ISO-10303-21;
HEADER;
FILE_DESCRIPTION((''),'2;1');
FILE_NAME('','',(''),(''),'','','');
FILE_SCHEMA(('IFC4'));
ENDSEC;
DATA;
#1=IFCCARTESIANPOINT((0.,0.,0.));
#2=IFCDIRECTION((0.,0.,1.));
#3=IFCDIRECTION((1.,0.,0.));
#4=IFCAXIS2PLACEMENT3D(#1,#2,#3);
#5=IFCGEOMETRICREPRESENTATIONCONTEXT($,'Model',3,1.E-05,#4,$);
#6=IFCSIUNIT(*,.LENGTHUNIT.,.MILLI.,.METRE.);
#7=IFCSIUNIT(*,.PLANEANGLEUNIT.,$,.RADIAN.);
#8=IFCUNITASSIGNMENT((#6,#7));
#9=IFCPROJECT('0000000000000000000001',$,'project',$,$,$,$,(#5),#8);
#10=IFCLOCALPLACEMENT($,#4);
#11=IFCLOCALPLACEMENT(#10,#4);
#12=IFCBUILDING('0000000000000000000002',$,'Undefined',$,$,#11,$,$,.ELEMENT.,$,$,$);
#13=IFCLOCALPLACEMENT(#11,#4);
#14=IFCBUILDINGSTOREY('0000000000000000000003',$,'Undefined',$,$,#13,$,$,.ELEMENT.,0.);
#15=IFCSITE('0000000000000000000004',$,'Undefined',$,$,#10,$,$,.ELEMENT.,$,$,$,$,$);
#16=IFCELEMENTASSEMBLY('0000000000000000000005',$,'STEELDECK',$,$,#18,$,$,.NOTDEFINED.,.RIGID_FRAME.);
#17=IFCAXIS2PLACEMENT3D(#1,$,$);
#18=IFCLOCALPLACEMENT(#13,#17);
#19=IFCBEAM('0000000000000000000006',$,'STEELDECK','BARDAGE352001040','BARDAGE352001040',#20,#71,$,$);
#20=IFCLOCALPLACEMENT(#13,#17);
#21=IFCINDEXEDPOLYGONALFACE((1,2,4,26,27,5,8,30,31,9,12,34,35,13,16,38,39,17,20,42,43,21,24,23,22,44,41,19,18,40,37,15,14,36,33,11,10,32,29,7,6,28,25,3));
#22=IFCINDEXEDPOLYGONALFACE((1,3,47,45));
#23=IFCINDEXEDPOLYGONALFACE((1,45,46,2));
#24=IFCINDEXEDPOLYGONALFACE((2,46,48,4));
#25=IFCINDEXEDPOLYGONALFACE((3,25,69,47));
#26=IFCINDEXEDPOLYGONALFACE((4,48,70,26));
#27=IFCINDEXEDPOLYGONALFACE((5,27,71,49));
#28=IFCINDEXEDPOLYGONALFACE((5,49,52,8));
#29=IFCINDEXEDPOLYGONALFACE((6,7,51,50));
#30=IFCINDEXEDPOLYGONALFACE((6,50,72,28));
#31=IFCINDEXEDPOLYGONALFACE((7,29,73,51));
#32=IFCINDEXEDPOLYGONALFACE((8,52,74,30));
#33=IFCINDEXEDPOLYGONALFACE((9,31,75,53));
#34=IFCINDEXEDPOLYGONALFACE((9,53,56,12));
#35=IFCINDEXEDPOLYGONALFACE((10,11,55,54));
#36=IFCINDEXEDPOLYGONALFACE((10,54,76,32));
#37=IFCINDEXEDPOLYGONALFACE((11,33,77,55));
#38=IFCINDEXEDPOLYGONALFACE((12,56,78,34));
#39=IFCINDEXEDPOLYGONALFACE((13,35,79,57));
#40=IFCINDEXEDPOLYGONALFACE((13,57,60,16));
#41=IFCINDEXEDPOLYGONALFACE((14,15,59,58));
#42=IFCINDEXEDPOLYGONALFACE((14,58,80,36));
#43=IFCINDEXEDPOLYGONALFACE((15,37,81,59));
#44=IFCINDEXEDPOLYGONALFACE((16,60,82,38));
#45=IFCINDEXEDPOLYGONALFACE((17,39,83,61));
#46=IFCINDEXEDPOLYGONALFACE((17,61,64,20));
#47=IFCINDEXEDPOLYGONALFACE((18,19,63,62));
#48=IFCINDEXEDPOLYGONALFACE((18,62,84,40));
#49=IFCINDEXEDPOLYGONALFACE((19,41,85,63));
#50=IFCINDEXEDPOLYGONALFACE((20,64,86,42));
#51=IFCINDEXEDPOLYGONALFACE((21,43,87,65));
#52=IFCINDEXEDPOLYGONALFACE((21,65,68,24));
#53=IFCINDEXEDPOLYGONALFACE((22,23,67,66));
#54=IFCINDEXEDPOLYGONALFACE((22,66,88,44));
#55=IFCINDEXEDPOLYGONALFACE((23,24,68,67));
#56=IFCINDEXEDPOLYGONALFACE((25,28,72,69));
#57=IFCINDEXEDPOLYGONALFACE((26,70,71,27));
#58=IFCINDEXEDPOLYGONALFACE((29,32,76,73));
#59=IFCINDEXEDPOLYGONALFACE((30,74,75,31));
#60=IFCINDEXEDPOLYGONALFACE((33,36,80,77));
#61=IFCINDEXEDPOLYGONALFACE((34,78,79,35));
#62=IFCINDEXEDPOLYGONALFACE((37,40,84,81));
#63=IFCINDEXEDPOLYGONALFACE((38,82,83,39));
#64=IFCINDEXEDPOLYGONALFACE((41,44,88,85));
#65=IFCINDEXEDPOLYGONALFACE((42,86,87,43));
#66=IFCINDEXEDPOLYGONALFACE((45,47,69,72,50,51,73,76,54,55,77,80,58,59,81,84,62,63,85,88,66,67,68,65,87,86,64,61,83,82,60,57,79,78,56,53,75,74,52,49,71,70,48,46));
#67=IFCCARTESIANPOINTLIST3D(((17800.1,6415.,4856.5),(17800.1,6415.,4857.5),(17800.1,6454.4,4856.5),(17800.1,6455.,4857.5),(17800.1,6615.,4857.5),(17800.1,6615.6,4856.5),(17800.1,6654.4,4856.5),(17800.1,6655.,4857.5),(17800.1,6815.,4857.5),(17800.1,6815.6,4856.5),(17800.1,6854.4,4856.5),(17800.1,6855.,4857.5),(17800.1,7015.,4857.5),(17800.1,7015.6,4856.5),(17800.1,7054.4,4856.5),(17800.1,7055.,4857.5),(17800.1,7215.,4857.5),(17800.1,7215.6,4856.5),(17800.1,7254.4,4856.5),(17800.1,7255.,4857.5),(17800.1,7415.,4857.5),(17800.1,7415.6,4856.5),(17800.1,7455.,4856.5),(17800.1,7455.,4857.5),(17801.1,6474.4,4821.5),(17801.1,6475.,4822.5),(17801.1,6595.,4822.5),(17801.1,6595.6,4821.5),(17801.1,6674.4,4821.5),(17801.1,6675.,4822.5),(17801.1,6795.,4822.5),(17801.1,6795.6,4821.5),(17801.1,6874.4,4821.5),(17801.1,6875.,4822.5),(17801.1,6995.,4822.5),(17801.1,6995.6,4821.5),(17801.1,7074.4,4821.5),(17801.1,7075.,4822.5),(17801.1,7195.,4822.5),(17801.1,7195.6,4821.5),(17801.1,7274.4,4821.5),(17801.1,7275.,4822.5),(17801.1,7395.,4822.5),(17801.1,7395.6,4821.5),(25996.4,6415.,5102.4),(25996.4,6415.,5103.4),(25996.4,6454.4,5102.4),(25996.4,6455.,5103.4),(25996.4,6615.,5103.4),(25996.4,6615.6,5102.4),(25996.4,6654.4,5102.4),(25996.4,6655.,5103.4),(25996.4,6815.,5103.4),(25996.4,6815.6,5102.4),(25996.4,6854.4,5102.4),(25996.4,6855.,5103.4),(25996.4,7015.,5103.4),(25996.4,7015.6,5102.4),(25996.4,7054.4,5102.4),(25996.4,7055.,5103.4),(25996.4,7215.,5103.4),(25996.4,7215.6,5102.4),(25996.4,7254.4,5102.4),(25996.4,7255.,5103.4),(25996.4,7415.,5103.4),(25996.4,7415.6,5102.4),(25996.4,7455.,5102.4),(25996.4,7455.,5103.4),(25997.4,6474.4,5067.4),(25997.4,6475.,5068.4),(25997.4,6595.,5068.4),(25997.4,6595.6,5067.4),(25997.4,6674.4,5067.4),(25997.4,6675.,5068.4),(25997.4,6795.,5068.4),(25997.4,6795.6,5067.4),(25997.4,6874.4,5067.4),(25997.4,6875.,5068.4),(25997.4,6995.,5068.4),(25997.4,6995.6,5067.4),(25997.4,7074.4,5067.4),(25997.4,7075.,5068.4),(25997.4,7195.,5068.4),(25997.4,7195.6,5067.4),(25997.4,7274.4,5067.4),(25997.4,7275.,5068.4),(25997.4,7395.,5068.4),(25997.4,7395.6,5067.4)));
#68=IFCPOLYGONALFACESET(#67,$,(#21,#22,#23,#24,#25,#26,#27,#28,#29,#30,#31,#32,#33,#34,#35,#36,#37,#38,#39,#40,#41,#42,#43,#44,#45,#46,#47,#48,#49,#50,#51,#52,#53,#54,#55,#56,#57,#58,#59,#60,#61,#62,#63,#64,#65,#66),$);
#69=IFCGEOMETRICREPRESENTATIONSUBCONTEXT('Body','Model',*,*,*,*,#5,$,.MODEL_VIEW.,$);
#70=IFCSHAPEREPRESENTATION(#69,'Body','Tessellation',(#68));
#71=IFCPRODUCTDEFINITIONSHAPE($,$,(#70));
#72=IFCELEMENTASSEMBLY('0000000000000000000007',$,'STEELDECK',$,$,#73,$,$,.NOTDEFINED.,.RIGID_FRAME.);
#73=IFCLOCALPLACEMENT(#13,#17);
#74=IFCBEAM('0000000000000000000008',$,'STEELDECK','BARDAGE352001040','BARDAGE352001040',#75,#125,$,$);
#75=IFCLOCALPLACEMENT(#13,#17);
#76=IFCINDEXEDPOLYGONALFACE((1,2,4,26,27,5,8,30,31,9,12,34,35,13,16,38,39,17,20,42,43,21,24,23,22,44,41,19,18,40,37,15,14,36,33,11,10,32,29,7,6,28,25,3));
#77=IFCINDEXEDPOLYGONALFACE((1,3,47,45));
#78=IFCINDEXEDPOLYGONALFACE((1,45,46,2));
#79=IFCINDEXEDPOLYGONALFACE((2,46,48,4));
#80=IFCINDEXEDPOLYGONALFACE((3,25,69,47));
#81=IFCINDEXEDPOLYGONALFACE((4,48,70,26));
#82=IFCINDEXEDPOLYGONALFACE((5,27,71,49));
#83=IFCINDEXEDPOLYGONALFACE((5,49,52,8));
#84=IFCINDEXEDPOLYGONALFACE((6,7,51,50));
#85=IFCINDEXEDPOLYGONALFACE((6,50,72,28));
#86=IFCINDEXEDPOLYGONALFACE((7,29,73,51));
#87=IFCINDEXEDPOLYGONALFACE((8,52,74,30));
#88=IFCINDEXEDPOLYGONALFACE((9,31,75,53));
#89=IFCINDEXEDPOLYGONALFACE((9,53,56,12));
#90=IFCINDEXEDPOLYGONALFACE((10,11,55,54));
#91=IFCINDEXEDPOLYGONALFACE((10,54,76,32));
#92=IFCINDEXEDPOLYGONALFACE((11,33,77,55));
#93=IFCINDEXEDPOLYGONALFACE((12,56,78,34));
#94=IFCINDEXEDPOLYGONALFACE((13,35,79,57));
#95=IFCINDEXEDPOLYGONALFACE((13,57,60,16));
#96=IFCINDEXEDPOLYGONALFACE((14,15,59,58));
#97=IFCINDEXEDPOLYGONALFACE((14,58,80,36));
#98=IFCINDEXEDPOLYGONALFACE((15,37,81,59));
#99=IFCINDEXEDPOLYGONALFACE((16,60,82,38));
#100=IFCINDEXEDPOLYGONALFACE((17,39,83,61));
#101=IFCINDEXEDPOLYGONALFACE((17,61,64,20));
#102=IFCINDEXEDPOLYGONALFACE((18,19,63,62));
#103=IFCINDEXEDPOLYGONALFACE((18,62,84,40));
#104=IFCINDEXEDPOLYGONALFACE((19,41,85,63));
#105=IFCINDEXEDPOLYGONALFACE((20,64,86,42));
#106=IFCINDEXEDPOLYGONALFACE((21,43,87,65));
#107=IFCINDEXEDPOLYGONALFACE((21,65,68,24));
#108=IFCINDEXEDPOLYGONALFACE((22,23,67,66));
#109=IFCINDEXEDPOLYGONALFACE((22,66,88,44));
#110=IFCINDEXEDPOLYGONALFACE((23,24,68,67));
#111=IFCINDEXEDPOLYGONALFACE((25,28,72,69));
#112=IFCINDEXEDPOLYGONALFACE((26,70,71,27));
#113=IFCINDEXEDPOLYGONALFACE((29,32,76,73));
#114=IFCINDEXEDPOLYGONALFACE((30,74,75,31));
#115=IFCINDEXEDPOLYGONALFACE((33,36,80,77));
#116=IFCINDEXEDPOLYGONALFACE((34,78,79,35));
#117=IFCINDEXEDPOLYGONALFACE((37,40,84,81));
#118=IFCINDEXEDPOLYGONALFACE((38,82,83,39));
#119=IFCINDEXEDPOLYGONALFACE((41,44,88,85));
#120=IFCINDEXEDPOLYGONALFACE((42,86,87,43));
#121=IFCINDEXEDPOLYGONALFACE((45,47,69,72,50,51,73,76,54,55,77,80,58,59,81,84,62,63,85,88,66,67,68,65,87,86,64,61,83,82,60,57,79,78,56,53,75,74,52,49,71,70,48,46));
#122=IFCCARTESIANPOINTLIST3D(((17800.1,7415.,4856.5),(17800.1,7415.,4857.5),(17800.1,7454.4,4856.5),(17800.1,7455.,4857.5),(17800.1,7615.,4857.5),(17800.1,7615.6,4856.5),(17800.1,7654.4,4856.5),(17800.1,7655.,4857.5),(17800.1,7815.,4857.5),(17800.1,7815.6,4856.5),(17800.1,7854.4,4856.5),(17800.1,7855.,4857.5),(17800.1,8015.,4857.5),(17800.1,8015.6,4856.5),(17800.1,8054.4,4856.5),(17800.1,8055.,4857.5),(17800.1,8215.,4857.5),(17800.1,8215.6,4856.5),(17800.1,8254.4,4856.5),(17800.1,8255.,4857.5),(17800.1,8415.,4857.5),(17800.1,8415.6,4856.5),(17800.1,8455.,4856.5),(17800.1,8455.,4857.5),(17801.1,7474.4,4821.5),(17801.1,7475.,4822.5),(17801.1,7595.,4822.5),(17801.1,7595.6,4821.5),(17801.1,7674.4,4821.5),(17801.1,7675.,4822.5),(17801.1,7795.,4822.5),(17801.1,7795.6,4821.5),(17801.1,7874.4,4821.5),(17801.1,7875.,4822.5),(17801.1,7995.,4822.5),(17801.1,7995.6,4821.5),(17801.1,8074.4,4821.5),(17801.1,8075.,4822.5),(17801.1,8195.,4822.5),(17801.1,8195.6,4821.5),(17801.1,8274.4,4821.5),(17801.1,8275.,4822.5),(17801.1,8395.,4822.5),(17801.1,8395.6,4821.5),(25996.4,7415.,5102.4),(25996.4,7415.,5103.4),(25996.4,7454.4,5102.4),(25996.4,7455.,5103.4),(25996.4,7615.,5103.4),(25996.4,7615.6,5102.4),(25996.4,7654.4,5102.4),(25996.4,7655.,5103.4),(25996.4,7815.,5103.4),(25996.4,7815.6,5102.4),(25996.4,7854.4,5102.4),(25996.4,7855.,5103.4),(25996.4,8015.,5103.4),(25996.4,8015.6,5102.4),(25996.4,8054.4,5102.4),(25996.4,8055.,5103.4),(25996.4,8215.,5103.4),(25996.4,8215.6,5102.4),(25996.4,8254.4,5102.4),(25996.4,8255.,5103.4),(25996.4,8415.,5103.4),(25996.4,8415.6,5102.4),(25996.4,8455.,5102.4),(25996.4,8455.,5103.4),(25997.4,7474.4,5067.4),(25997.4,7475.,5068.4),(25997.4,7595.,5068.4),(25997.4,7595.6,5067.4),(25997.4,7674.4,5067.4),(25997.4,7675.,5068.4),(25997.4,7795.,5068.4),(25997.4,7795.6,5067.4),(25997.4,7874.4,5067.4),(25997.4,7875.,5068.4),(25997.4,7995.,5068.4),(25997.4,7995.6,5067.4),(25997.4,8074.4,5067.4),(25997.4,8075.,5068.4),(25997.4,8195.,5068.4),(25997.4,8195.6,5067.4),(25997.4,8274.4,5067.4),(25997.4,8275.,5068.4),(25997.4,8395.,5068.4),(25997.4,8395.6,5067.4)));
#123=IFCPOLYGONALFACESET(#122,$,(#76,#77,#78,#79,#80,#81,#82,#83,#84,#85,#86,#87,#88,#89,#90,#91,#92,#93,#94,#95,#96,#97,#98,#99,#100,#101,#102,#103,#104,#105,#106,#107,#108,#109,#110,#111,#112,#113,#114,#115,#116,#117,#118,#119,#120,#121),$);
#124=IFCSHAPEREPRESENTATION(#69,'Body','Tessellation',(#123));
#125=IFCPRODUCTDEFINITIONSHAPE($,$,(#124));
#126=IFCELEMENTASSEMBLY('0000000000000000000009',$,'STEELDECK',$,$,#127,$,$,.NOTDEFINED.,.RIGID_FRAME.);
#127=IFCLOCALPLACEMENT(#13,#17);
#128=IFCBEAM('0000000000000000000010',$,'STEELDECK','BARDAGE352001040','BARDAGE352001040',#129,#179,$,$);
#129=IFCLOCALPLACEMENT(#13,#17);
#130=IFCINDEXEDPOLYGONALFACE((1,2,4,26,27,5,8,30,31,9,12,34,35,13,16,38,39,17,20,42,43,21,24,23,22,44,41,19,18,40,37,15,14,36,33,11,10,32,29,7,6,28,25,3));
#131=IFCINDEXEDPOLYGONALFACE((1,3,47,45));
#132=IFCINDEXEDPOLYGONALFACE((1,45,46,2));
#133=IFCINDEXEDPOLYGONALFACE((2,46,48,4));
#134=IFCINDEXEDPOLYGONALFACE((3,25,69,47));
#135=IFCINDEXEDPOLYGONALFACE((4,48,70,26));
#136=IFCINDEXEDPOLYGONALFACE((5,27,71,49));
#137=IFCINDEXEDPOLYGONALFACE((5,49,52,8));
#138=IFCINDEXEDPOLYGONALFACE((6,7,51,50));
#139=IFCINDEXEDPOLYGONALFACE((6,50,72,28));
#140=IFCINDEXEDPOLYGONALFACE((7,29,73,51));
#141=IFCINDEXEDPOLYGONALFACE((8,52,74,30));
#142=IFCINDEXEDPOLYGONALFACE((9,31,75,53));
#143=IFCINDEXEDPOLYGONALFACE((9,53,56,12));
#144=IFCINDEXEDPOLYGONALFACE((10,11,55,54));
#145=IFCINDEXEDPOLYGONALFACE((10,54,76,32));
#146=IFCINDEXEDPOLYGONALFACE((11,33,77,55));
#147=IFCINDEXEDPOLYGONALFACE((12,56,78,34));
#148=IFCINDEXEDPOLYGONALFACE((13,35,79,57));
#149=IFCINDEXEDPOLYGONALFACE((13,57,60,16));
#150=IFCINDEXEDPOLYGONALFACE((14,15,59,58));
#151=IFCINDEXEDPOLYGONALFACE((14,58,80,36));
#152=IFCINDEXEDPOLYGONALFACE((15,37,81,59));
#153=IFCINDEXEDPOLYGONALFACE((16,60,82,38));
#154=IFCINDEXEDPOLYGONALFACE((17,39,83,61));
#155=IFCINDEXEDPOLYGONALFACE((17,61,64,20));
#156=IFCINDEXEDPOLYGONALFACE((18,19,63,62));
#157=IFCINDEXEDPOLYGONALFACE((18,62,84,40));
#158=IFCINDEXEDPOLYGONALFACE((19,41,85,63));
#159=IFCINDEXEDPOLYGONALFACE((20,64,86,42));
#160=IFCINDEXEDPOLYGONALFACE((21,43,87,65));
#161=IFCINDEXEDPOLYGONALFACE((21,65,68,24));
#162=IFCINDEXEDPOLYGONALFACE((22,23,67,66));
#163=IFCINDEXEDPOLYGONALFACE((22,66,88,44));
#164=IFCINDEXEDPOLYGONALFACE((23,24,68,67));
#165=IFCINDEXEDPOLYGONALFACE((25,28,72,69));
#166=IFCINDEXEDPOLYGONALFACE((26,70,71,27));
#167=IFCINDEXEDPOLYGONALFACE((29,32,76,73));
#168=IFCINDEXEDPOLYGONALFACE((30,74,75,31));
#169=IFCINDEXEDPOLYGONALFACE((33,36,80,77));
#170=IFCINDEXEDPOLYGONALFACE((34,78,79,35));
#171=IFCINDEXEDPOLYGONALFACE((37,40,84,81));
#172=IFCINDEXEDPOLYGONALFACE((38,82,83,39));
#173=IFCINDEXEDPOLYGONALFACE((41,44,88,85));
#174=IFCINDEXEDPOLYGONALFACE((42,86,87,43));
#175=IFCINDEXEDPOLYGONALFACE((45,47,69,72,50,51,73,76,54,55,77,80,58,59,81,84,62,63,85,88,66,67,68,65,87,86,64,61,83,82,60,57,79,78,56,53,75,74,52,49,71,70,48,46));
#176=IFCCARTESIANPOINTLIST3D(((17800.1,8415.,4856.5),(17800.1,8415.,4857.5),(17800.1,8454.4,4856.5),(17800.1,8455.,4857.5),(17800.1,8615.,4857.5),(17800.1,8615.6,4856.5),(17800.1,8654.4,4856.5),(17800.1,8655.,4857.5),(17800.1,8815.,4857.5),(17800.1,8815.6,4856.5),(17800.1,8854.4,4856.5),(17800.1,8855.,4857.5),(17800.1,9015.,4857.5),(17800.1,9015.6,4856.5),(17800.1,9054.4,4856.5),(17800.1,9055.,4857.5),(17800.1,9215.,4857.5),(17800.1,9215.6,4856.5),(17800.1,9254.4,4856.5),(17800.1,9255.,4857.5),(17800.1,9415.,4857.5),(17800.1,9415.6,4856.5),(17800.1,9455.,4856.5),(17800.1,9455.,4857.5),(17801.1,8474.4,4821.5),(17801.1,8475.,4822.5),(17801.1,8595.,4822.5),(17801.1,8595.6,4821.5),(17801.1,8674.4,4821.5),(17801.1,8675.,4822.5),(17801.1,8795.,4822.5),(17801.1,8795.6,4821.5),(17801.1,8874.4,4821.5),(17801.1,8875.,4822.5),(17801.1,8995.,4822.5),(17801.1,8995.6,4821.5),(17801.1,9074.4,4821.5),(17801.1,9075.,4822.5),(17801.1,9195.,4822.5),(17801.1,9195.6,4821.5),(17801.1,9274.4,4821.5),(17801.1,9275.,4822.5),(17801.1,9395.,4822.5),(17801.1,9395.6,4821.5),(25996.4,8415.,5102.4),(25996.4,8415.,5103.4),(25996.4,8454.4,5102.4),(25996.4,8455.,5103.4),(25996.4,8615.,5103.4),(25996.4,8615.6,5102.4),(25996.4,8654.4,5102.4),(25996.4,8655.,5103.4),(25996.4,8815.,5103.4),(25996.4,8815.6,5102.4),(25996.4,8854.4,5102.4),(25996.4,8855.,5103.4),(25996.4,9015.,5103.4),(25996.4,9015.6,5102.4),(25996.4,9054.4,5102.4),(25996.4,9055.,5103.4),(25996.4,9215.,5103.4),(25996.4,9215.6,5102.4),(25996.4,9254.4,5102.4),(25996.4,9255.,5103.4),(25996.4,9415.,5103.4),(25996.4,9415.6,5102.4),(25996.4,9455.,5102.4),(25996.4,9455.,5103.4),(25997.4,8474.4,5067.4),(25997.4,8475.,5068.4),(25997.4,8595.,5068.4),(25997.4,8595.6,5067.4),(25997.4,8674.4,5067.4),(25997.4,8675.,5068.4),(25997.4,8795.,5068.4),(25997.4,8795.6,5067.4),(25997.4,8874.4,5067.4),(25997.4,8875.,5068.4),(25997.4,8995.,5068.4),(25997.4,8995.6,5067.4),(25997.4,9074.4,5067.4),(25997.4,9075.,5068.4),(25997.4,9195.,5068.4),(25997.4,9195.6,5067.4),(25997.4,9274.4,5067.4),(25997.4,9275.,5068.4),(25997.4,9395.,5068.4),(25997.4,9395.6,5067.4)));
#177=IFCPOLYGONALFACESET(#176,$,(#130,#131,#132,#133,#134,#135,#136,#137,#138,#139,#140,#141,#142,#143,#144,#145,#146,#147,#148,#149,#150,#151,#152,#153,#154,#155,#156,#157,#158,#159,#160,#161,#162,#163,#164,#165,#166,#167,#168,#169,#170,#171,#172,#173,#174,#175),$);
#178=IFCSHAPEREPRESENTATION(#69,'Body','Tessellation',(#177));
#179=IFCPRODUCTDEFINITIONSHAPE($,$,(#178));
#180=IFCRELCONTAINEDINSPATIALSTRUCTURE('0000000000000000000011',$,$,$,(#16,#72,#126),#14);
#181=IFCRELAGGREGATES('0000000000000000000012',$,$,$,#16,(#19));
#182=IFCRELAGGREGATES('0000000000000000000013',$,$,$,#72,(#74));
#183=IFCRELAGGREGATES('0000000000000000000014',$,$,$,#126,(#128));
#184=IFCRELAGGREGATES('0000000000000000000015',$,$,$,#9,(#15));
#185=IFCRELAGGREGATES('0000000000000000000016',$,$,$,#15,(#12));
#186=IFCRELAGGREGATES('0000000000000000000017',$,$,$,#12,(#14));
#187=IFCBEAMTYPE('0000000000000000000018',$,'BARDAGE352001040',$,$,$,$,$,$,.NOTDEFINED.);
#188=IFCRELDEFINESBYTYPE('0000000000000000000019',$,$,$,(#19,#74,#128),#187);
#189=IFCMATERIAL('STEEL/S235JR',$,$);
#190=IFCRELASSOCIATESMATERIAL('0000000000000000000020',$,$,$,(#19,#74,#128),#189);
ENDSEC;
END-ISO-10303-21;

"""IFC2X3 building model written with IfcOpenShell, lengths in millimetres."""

from ifc_helpers import new_model, si_unit, frame, origin_with_axes, place, context, subcontext, project, spatial, polyline, outline, extrude, material, type_object, element, aggregate, save


model = new_model("IFC2X3")

# Units and contexts
model_context = context("Model", 3, precision=1e-05, world=origin_with_axes())
body_context = subcontext(model_context, "Body", "Model", "MODEL_VIEW")
ifc_project = project(units=[si_unit("LENGTHUNIT", "METRE", prefix="MILLI"), si_unit("PLANEANGLEUNIT", "RADIAN")], contexts=[model_context])

# Site, building, storey
site_placement = place(None, origin_with_axes())
site = spatial("IfcSite", under=ifc_project, at=site_placement, Name="Undefined", CompositionType="ELEMENT")
building_placement = place(site_placement, origin_with_axes())
building = spatial("IfcBuilding", under=site, at=building_placement, Name="Undefined", CompositionType="ELEMENT")
storey_placement = place(building_placement, origin_with_axes())
storey = spatial("IfcBuildingStorey", under=building, at=storey_placement, Name="Undefined", CompositionType="ELEMENT", Elevation=0.0)

# Element assemblies, beams
ifc_material_1 = material(Name="STEEL/S235JR")
beam_type_1 = type_object("IfcBeamType", Name="BARDAGE352001040", PredefinedType="NOTDEFINED")
assembly_1_placement = place(storey_placement, origin_with_axes())
assembly_1 = element("IfcElementAssembly", 1, at=assembly_1_placement, inside=storey, Name="STEELDECK", AssemblyPlace="NOTDEFINED", PredefinedType="RIGID_FRAME")
beam_1_placement = place(assembly_1_placement, frame((17800.1, 7455.0, 4857.5), z_axis=(-0.029987, 0.0, 0.99955), x_axis=(0.99955, 0.0, 0.029986)))
beam_1 = element("IfcBeam", 2, at=beam_1_placement, type_object=beam_type_1, material=ifc_material_1, Name="STEELDECK", Description="BARDAGE352001040", ObjectType="BARDAGE352001040", context=body_context, shape_type="SweptSolid", body=[
    extrude(outline(polyline([(200.6, -1.0), (180.6, -36.0), (59.4, -36.0), (39.4, -1.0), (0.0, -1.0), (0.0, 0.0), (40.0, 0.0), (60.0, -35.0), (180.0, -35.0), (200.0, 0.0), (240.0, 0.0), (260.0, -35.0), (380.0, -35.0), (400.0, 0.0), (440.0, 0.0), (460.0, -35.0), (580.0, -35.0), (600.0, 0.0), (640.0, 0.0), (660.0, -35.0), (780.0, -35.0), (800.0, 0.0), (840.0, 0.0), (860.0, -35.0), (980.0, -35.0), (1000.0, 0.0), (1040.0, 0.0), (1040.0, -1.0), (1000.6, -1.0), (980.6, -36.0), (859.4, -36.0), (839.4, -1.0), (800.6, -1.0), (780.6, -36.0), (659.4, -36.0), (639.4, -1.0), (600.6, -1.0), (580.6, -36.0), (459.4, -36.0), (439.4, -1.0), (400.6, -1.0), (380.6, -36.0), (259.4, -36.0), (239.4, -1.0), (200.6, -1.0)])), frame((8200.0, 0.0, 0.0), z_axis=(-1.0, 0.0, 0.0), x_axis=(0.0, -1.0, 0.0)), (0.0, 0.0, 1.0), 8200.0),
])
aggregate(assembly_1, [beam_1])
assembly_2_placement = place(storey_placement, origin_with_axes())
assembly_2 = element("IfcElementAssembly", 3, at=assembly_2_placement, inside=storey, Name="STEELDECK", AssemblyPlace="NOTDEFINED", PredefinedType="RIGID_FRAME")
beam_2_placement = place(assembly_2_placement, frame((17800.1, 8455.0, 4857.5), z_axis=(-0.029987, 0.0, 0.99955), x_axis=(0.99955, 0.0, 0.029986)))
beam_2 = element("IfcBeam", 4, at=beam_2_placement, type_object=beam_type_1, material=ifc_material_1, Name="STEELDECK", Description="BARDAGE352001040", ObjectType="BARDAGE352001040", context=body_context, shape_type="SweptSolid", body=[
    extrude(outline(polyline([(200.6, -1.0), (180.6, -36.0), (59.4, -36.0), (39.4, -1.0), (0.0, -1.0), (0.0, 0.0), (40.0, 0.0), (60.0, -35.0), (180.0, -35.0), (200.0, 0.0), (240.0, 0.0), (260.0, -35.0), (380.0, -35.0), (400.0, 0.0), (440.0, 0.0), (460.0, -35.0), (580.0, -35.0), (600.0, 0.0), (640.0, 0.0), (660.0, -35.0), (780.0, -35.0), (800.0, 0.0), (840.0, 0.0), (860.0, -35.0), (980.0, -35.0), (1000.0, 0.0), (1040.0, 0.0), (1040.0, -1.0), (1000.6, -1.0), (980.6, -36.0), (859.4, -36.0), (839.4, -1.0), (800.6, -1.0), (780.6, -36.0), (659.4, -36.0), (639.4, -1.0), (600.6, -1.0), (580.6, -36.0), (459.4, -36.0), (439.4, -1.0), (400.6, -1.0), (380.6, -36.0), (259.4, -36.0), (239.4, -1.0), (200.6, -1.0)])), frame((8200.0, 0.0, 0.0), z_axis=(-1.0, 0.0, 0.0), x_axis=(0.0, -1.0, 0.0)), (0.0, 0.0, 1.0), 8200.0),
])
aggregate(assembly_2, [beam_2])
assembly_3_placement = place(storey_placement, origin_with_axes())
assembly_3 = element("IfcElementAssembly", 5, at=assembly_3_placement, inside=storey, Name="STEELDECK", AssemblyPlace="NOTDEFINED", PredefinedType="RIGID_FRAME")
beam_3_placement = place(assembly_3_placement, frame((17800.1, 9455.0, 4857.5), z_axis=(-0.029987, 0.0, 0.99955), x_axis=(0.99955, 0.0, 0.029986)))
beam_3 = element("IfcBeam", 6, at=beam_3_placement, type_object=beam_type_1, material=ifc_material_1, Name="STEELDECK", Description="BARDAGE352001040", ObjectType="BARDAGE352001040", context=body_context, shape_type="SweptSolid", body=[
    extrude(outline(polyline([(200.6, -1.0), (180.6, -36.0), (59.4, -36.0), (39.4, -1.0), (0.0, -1.0), (0.0, 0.0), (40.0, 0.0), (60.0, -35.0), (180.0, -35.0), (200.0, 0.0), (240.0, 0.0), (260.0, -35.0), (380.0, -35.0), (400.0, 0.0), (440.0, 0.0), (460.0, -35.0), (580.0, -35.0), (600.0, 0.0), (640.0, 0.0), (660.0, -35.0), (780.0, -35.0), (800.0, 0.0), (840.0, 0.0), (860.0, -35.0), (980.0, -35.0), (1000.0, 0.0), (1040.0, 0.0), (1040.0, -1.0), (1000.6, -1.0), (980.6, -36.0), (859.4, -36.0), (839.4, -1.0), (800.6, -1.0), (780.6, -36.0), (659.4, -36.0), (639.4, -1.0), (600.6, -1.0), (580.6, -36.0), (459.4, -36.0), (439.4, -1.0), (400.6, -1.0), (380.6, -36.0), (259.4, -36.0), (239.4, -1.0), (200.6, -1.0)])), frame((8200.0, 0.0, 0.0), z_axis=(-1.0, 0.0, 0.0), x_axis=(0.0, -1.0, 0.0)), (0.0, 0.0, 1.0), 8200.0),
])
aggregate(assembly_3, [beam_3])

save(model, "model.ifc")
